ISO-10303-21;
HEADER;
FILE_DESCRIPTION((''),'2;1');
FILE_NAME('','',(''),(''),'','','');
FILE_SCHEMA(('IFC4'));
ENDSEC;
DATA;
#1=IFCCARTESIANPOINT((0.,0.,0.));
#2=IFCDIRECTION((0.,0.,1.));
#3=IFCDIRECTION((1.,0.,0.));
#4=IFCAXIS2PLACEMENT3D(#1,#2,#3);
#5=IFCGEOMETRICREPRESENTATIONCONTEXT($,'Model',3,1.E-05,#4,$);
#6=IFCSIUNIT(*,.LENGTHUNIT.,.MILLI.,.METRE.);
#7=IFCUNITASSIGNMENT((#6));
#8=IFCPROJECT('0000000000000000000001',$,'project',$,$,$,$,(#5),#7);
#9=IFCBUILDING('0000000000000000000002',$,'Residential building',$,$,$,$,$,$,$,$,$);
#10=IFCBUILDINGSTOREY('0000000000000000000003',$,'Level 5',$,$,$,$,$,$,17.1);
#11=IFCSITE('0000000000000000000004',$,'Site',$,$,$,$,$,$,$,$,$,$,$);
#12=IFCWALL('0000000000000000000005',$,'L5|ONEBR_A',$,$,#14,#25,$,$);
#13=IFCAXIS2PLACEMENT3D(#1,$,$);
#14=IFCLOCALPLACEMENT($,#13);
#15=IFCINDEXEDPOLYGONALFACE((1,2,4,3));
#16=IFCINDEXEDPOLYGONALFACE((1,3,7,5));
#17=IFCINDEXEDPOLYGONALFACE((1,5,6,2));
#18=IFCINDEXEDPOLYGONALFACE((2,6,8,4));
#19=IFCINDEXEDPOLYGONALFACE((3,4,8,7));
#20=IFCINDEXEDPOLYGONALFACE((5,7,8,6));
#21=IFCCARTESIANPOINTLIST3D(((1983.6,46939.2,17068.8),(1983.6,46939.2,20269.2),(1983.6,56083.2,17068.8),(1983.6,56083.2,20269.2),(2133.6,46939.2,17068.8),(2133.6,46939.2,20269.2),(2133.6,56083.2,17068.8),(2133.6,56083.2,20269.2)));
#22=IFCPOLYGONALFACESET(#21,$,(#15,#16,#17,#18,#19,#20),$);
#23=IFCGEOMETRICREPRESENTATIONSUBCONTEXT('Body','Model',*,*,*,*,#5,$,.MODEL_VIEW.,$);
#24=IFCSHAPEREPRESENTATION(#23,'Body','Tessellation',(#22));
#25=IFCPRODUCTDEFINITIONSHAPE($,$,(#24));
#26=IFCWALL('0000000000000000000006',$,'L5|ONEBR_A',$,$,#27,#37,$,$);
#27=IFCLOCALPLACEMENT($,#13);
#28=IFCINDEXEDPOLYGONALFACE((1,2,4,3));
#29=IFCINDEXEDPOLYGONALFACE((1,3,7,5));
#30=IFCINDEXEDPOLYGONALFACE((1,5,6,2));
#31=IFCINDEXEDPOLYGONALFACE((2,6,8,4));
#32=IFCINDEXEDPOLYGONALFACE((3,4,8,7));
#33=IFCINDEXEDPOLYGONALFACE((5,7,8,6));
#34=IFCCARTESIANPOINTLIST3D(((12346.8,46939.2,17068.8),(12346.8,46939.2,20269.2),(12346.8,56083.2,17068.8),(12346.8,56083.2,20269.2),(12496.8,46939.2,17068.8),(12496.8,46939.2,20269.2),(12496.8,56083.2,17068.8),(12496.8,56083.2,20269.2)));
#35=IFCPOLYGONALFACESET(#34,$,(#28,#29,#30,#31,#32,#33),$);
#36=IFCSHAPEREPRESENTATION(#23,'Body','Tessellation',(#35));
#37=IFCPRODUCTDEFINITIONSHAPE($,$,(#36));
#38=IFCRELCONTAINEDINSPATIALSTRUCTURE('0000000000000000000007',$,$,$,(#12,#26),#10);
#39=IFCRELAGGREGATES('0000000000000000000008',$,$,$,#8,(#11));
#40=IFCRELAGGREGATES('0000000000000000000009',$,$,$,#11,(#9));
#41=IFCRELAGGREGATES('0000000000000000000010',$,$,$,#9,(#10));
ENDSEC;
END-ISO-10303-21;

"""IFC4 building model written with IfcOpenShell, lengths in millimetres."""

from ifc_helpers import new_model, si_unit, frame, origin_with_axes, place, context, subcontext, project, spatial, indexed_curve, outline, extrude, element, save


model = new_model("IFC4")

# Units and contexts
model_context = context("Model", 3, precision=1e-05, world=origin_with_axes())
body_context = subcontext(model_context, "Body", "Model", "MODEL_VIEW")
ifc_project = project(units=[si_unit("LENGTHUNIT", "METRE", prefix="MILLI")], contexts=[model_context])

# Site, building, storey
site = spatial("IfcSite", under=ifc_project, Name="Site")
building = spatial("IfcBuilding", under=site, Name="Residential building")
storey = spatial("IfcBuildingStorey", under=building, Name="Level 5", Elevation=17.1)

# Walls
for number, where, z_axis, x_axis, name in (
    (1, (2133.6, 46939.2, 17068.8), (0.0, 0.0, 1.0), (0.0, 1.0, 0.0), "L5|ONEBR_A"),
    (2, (12496.8, 46939.2, 17068.8), (0.0, 0.0, 1.0), (0.0, 1.0, 0.0), "L5|ONEBR_A"),
):
    element("IfcWall", number, at=place(None, frame(where, z_axis=z_axis, x_axis=x_axis)), inside=storey, Name=name, context=body_context, shape_type="SweptSolid", body=[
        extrude(outline(indexed_curve([(0.0, 0.0), (0.0, 150.0), (9144.0, 150.0), (9144.0, 0.0), (0.0, 0.0)], self_intersect=False)), origin_with_axes(), (0.0, 0.0, 1.0), 3200.4),
    ])

save(model, "model.ifc")
